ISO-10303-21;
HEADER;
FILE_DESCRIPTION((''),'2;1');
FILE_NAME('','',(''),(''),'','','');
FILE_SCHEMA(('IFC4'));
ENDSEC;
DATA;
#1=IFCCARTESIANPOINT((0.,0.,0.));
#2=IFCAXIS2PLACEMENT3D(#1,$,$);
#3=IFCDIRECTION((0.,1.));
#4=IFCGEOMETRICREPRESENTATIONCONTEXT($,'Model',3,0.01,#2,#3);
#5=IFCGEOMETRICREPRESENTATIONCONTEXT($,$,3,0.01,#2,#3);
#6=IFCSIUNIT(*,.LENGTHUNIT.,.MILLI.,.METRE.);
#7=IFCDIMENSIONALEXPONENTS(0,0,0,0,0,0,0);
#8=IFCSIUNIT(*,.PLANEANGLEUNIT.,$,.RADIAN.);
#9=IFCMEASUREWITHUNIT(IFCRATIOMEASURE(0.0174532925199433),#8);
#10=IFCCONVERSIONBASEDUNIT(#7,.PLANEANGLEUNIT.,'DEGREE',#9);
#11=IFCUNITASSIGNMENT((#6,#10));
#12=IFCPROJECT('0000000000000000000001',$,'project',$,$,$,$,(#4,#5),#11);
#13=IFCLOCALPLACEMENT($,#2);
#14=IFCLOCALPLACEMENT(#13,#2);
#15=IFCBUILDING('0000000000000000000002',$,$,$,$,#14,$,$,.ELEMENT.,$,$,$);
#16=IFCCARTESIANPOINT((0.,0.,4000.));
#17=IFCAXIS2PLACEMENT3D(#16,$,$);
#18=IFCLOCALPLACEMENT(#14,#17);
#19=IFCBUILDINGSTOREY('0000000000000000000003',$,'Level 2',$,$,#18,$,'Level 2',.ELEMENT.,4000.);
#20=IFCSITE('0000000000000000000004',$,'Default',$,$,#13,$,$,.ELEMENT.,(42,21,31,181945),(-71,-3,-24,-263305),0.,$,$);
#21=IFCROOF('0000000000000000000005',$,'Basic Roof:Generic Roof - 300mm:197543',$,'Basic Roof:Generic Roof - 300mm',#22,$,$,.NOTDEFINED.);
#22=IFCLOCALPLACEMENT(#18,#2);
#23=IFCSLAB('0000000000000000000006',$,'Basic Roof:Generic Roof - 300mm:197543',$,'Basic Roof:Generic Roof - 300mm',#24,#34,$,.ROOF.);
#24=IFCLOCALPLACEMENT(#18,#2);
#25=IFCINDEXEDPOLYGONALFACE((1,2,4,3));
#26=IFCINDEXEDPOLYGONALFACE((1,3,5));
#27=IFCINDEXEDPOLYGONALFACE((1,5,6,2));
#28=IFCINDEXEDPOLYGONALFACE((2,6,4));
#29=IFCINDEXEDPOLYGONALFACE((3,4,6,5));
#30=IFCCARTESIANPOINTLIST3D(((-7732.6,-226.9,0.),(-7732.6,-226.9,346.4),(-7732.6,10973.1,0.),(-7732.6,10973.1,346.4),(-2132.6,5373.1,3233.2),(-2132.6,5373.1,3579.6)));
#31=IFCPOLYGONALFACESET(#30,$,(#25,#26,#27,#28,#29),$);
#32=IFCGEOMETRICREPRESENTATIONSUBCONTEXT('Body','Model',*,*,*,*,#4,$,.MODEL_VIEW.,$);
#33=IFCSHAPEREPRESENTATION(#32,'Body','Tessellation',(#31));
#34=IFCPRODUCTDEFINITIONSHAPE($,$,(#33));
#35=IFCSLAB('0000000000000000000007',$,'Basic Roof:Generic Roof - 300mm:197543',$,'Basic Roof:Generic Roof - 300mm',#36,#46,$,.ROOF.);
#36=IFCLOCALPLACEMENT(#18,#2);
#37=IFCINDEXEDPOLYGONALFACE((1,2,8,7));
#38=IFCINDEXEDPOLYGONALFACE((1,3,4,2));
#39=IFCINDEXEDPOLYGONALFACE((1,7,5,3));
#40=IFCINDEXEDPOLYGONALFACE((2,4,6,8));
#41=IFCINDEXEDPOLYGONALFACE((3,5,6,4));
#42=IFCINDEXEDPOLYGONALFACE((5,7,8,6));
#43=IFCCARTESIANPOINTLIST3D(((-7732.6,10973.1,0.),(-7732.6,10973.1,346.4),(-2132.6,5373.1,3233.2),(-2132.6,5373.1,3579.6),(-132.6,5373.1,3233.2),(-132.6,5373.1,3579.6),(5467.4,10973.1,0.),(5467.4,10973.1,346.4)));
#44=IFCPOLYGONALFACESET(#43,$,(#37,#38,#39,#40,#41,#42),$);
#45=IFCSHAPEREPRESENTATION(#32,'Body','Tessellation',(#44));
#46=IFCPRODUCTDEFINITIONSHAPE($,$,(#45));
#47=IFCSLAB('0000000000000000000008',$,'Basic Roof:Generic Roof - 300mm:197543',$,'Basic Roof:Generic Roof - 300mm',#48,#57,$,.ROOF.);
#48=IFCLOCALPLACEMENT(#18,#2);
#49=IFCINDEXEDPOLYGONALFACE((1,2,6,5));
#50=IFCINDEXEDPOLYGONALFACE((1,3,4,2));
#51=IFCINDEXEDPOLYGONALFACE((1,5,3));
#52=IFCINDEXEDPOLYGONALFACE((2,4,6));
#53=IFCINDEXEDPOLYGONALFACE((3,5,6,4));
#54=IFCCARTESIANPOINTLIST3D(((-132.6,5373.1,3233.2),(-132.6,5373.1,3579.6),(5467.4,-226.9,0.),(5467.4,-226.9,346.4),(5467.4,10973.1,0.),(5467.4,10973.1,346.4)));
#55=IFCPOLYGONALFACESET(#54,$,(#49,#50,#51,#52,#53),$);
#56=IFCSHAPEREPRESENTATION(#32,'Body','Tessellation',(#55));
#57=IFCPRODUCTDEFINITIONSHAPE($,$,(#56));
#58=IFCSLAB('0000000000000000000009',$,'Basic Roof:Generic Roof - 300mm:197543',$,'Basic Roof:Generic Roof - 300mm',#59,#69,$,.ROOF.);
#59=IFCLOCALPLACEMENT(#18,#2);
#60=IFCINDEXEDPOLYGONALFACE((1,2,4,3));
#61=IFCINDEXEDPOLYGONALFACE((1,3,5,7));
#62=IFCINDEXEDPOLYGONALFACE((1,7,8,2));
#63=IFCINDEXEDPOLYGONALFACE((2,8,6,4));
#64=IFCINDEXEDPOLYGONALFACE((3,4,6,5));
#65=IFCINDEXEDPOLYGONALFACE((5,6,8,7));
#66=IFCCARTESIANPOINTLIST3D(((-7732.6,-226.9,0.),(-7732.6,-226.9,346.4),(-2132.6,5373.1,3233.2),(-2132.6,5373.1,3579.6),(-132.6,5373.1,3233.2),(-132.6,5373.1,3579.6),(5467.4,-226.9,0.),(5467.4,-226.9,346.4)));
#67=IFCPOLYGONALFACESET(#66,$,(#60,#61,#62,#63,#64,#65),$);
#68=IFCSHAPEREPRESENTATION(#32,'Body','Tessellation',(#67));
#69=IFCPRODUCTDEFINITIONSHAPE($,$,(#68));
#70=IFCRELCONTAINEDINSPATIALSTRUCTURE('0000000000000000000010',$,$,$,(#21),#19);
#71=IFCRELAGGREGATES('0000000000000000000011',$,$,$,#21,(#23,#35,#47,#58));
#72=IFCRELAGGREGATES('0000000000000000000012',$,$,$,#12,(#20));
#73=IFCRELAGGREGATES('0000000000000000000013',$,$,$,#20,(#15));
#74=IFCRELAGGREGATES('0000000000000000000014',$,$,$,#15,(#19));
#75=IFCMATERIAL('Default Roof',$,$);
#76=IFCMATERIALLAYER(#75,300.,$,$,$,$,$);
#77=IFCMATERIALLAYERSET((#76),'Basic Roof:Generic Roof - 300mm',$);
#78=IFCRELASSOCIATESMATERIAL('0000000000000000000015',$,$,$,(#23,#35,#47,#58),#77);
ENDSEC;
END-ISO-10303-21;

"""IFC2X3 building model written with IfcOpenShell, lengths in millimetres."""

from ifc_helpers import new_model, entity, si_unit, converted_unit, direction, frame, origin, place, context, subcontext, project, spatial, polyline, outline, extrude, material, layer, layer_set, element, aggregate, save


model = new_model("IFC2X3")

# Units and contexts
model_context = context("Model", 3, precision=0.01, world=origin(), true_north=direction((0.0, 1.0)))
context_of_model = context(None, 3, precision=0.01, world=origin(), true_north=direction((0.0, 1.0)))
body_context = subcontext(model_context, "Body", "Model", "MODEL_VIEW")
ifc_project = project(units=[si_unit("LENGTHUNIT", "METRE", prefix="MILLI"), converted_unit("PLANEANGLEUNIT", "DEGREE", entity("IfcRatioMeasure", 0.0174532925199433), si_unit("PLANEANGLEUNIT", "RADIAN"), dimensions=[0, 0, 0, 0, 0, 0, 0])], contexts=[model_context, context_of_model])

# Site, building, storey
site_placement = place(None, origin())
site = spatial("IfcSite", under=ifc_project, at=site_placement, Name="Default", CompositionType="ELEMENT", RefLatitude=(42, 21, 31, 181945), RefLongitude=(-71, -3, -24, -263305), RefElevation=0.0)
building_placement = place(site_placement, origin())
building = spatial("IfcBuilding", under=site, at=building_placement, CompositionType="ELEMENT")
storey_placement = place(building_placement, frame((0.0, 0.0, 4000.0)))
storey = spatial("IfcBuildingStorey", under=building, at=storey_placement, Name="Level 2", LongName="Level 2", CompositionType="ELEMENT", Elevation=4000.0)

# Roof, slabs
roof_placement = place(storey_placement, frame((-7732.6, -226.9, 0.0)))
roof = element("IfcRoof", 1, at=roof_placement, inside=storey, Name="Basic Roof:Generic Roof - 300mm:197543", ObjectType="Basic Roof:Generic Roof - 300mm", ShapeType="NOTDEFINED")
ifc_material = material(Name="Default Roof")
ifc_layer = layer(ifc_material, 300.0)
ifc_layer_set = layer_set([ifc_layer], Name="Basic Roof:Generic Roof - 300mm")
slab_1_placement = place(roof_placement, origin())
slab_1 = element("IfcSlab", 2, at=slab_1_placement, material=ifc_layer_set, Name="Basic Roof:Generic Roof - 300mm:197543", ObjectType="Basic Roof:Generic Roof - 300mm", PredefinedType="ROOF", context=body_context, shape_type="SweptSolid", body=[
    extrude(outline(polyline([(3233.2, 0.0), (-3233.2, 5600.0), (-3233.2, -5600.0), (3233.2, 0.0)])), frame((2800.0, 5600.0, 1616.6), z_axis=(-0.5, 0.0, 0.866025), x_axis=(0.866025, 0.0, 0.5)), (0.5, 0.0, 0.866025), 346.4),
])
slab_2_placement = place(roof_placement, origin())
slab_2 = element("IfcSlab", 3, at=slab_2_placement, material=ifc_layer_set, Name="Basic Roof:Generic Roof - 300mm:197543", ObjectType="Basic Roof:Generic Roof - 300mm", PredefinedType="ROOF", context=body_context, shape_type="SweptSolid", body=[
    extrude(outline(polyline([(6600.0, 3233.2), (-6600.0, 3233.2), (-1000.0, -3233.2), (1000.0, -3233.2), (6600.0, 3233.2)])), frame((6600.0, 8400.0, 1616.6), z_axis=(0.0, 0.5, 0.866025), x_axis=(1.0, 0.0, 0.0)), (0.0, -0.5, 0.866025), 346.4),
])
slab_3_placement = place(roof_placement, origin())
slab_3 = element("IfcSlab", 4, at=slab_3_placement, material=ifc_layer_set, Name="Basic Roof:Generic Roof - 300mm:197543", ObjectType="Basic Roof:Generic Roof - 300mm", PredefinedType="ROOF", context=body_context, shape_type="SweptSolid", body=[
    extrude(outline(polyline([(3233.2, -5600.0), (3233.2, 5600.0), (-3233.2, 0.0), (3233.2, -5600.0)])), frame((10400.0, 5600.0, 1616.6), z_axis=(0.5, 0.0, 0.866025), x_axis=(0.866025, 0.0, -0.5)), (-0.5, 0.0, 0.866025), 346.4),
])
slab_4_placement = place(roof_placement, origin())
slab_4 = element("IfcSlab", 5, at=slab_4_placement, material=ifc_layer_set, Name="Basic Roof:Generic Roof - 300mm:197543", ObjectType="Basic Roof:Generic Roof - 300mm", PredefinedType="ROOF", context=body_context, shape_type="SweptSolid", body=[
    extrude(outline(polyline([(-6600.0, -3233.2), (6600.0, -3233.2), (1000.0, 3233.2), (-1000.0, 3233.2), (-6600.0, -3233.2)])), frame((6600.0, 2800.0, 1616.6), z_axis=(0.0, -0.5, 0.866025), x_axis=(1.0, 0.0, 0.0)), (0.0, 0.5, 0.866025), 346.4),
])
aggregate(roof, [slab_1, slab_2, slab_3, slab_4])

save(model, "model.ifc")
